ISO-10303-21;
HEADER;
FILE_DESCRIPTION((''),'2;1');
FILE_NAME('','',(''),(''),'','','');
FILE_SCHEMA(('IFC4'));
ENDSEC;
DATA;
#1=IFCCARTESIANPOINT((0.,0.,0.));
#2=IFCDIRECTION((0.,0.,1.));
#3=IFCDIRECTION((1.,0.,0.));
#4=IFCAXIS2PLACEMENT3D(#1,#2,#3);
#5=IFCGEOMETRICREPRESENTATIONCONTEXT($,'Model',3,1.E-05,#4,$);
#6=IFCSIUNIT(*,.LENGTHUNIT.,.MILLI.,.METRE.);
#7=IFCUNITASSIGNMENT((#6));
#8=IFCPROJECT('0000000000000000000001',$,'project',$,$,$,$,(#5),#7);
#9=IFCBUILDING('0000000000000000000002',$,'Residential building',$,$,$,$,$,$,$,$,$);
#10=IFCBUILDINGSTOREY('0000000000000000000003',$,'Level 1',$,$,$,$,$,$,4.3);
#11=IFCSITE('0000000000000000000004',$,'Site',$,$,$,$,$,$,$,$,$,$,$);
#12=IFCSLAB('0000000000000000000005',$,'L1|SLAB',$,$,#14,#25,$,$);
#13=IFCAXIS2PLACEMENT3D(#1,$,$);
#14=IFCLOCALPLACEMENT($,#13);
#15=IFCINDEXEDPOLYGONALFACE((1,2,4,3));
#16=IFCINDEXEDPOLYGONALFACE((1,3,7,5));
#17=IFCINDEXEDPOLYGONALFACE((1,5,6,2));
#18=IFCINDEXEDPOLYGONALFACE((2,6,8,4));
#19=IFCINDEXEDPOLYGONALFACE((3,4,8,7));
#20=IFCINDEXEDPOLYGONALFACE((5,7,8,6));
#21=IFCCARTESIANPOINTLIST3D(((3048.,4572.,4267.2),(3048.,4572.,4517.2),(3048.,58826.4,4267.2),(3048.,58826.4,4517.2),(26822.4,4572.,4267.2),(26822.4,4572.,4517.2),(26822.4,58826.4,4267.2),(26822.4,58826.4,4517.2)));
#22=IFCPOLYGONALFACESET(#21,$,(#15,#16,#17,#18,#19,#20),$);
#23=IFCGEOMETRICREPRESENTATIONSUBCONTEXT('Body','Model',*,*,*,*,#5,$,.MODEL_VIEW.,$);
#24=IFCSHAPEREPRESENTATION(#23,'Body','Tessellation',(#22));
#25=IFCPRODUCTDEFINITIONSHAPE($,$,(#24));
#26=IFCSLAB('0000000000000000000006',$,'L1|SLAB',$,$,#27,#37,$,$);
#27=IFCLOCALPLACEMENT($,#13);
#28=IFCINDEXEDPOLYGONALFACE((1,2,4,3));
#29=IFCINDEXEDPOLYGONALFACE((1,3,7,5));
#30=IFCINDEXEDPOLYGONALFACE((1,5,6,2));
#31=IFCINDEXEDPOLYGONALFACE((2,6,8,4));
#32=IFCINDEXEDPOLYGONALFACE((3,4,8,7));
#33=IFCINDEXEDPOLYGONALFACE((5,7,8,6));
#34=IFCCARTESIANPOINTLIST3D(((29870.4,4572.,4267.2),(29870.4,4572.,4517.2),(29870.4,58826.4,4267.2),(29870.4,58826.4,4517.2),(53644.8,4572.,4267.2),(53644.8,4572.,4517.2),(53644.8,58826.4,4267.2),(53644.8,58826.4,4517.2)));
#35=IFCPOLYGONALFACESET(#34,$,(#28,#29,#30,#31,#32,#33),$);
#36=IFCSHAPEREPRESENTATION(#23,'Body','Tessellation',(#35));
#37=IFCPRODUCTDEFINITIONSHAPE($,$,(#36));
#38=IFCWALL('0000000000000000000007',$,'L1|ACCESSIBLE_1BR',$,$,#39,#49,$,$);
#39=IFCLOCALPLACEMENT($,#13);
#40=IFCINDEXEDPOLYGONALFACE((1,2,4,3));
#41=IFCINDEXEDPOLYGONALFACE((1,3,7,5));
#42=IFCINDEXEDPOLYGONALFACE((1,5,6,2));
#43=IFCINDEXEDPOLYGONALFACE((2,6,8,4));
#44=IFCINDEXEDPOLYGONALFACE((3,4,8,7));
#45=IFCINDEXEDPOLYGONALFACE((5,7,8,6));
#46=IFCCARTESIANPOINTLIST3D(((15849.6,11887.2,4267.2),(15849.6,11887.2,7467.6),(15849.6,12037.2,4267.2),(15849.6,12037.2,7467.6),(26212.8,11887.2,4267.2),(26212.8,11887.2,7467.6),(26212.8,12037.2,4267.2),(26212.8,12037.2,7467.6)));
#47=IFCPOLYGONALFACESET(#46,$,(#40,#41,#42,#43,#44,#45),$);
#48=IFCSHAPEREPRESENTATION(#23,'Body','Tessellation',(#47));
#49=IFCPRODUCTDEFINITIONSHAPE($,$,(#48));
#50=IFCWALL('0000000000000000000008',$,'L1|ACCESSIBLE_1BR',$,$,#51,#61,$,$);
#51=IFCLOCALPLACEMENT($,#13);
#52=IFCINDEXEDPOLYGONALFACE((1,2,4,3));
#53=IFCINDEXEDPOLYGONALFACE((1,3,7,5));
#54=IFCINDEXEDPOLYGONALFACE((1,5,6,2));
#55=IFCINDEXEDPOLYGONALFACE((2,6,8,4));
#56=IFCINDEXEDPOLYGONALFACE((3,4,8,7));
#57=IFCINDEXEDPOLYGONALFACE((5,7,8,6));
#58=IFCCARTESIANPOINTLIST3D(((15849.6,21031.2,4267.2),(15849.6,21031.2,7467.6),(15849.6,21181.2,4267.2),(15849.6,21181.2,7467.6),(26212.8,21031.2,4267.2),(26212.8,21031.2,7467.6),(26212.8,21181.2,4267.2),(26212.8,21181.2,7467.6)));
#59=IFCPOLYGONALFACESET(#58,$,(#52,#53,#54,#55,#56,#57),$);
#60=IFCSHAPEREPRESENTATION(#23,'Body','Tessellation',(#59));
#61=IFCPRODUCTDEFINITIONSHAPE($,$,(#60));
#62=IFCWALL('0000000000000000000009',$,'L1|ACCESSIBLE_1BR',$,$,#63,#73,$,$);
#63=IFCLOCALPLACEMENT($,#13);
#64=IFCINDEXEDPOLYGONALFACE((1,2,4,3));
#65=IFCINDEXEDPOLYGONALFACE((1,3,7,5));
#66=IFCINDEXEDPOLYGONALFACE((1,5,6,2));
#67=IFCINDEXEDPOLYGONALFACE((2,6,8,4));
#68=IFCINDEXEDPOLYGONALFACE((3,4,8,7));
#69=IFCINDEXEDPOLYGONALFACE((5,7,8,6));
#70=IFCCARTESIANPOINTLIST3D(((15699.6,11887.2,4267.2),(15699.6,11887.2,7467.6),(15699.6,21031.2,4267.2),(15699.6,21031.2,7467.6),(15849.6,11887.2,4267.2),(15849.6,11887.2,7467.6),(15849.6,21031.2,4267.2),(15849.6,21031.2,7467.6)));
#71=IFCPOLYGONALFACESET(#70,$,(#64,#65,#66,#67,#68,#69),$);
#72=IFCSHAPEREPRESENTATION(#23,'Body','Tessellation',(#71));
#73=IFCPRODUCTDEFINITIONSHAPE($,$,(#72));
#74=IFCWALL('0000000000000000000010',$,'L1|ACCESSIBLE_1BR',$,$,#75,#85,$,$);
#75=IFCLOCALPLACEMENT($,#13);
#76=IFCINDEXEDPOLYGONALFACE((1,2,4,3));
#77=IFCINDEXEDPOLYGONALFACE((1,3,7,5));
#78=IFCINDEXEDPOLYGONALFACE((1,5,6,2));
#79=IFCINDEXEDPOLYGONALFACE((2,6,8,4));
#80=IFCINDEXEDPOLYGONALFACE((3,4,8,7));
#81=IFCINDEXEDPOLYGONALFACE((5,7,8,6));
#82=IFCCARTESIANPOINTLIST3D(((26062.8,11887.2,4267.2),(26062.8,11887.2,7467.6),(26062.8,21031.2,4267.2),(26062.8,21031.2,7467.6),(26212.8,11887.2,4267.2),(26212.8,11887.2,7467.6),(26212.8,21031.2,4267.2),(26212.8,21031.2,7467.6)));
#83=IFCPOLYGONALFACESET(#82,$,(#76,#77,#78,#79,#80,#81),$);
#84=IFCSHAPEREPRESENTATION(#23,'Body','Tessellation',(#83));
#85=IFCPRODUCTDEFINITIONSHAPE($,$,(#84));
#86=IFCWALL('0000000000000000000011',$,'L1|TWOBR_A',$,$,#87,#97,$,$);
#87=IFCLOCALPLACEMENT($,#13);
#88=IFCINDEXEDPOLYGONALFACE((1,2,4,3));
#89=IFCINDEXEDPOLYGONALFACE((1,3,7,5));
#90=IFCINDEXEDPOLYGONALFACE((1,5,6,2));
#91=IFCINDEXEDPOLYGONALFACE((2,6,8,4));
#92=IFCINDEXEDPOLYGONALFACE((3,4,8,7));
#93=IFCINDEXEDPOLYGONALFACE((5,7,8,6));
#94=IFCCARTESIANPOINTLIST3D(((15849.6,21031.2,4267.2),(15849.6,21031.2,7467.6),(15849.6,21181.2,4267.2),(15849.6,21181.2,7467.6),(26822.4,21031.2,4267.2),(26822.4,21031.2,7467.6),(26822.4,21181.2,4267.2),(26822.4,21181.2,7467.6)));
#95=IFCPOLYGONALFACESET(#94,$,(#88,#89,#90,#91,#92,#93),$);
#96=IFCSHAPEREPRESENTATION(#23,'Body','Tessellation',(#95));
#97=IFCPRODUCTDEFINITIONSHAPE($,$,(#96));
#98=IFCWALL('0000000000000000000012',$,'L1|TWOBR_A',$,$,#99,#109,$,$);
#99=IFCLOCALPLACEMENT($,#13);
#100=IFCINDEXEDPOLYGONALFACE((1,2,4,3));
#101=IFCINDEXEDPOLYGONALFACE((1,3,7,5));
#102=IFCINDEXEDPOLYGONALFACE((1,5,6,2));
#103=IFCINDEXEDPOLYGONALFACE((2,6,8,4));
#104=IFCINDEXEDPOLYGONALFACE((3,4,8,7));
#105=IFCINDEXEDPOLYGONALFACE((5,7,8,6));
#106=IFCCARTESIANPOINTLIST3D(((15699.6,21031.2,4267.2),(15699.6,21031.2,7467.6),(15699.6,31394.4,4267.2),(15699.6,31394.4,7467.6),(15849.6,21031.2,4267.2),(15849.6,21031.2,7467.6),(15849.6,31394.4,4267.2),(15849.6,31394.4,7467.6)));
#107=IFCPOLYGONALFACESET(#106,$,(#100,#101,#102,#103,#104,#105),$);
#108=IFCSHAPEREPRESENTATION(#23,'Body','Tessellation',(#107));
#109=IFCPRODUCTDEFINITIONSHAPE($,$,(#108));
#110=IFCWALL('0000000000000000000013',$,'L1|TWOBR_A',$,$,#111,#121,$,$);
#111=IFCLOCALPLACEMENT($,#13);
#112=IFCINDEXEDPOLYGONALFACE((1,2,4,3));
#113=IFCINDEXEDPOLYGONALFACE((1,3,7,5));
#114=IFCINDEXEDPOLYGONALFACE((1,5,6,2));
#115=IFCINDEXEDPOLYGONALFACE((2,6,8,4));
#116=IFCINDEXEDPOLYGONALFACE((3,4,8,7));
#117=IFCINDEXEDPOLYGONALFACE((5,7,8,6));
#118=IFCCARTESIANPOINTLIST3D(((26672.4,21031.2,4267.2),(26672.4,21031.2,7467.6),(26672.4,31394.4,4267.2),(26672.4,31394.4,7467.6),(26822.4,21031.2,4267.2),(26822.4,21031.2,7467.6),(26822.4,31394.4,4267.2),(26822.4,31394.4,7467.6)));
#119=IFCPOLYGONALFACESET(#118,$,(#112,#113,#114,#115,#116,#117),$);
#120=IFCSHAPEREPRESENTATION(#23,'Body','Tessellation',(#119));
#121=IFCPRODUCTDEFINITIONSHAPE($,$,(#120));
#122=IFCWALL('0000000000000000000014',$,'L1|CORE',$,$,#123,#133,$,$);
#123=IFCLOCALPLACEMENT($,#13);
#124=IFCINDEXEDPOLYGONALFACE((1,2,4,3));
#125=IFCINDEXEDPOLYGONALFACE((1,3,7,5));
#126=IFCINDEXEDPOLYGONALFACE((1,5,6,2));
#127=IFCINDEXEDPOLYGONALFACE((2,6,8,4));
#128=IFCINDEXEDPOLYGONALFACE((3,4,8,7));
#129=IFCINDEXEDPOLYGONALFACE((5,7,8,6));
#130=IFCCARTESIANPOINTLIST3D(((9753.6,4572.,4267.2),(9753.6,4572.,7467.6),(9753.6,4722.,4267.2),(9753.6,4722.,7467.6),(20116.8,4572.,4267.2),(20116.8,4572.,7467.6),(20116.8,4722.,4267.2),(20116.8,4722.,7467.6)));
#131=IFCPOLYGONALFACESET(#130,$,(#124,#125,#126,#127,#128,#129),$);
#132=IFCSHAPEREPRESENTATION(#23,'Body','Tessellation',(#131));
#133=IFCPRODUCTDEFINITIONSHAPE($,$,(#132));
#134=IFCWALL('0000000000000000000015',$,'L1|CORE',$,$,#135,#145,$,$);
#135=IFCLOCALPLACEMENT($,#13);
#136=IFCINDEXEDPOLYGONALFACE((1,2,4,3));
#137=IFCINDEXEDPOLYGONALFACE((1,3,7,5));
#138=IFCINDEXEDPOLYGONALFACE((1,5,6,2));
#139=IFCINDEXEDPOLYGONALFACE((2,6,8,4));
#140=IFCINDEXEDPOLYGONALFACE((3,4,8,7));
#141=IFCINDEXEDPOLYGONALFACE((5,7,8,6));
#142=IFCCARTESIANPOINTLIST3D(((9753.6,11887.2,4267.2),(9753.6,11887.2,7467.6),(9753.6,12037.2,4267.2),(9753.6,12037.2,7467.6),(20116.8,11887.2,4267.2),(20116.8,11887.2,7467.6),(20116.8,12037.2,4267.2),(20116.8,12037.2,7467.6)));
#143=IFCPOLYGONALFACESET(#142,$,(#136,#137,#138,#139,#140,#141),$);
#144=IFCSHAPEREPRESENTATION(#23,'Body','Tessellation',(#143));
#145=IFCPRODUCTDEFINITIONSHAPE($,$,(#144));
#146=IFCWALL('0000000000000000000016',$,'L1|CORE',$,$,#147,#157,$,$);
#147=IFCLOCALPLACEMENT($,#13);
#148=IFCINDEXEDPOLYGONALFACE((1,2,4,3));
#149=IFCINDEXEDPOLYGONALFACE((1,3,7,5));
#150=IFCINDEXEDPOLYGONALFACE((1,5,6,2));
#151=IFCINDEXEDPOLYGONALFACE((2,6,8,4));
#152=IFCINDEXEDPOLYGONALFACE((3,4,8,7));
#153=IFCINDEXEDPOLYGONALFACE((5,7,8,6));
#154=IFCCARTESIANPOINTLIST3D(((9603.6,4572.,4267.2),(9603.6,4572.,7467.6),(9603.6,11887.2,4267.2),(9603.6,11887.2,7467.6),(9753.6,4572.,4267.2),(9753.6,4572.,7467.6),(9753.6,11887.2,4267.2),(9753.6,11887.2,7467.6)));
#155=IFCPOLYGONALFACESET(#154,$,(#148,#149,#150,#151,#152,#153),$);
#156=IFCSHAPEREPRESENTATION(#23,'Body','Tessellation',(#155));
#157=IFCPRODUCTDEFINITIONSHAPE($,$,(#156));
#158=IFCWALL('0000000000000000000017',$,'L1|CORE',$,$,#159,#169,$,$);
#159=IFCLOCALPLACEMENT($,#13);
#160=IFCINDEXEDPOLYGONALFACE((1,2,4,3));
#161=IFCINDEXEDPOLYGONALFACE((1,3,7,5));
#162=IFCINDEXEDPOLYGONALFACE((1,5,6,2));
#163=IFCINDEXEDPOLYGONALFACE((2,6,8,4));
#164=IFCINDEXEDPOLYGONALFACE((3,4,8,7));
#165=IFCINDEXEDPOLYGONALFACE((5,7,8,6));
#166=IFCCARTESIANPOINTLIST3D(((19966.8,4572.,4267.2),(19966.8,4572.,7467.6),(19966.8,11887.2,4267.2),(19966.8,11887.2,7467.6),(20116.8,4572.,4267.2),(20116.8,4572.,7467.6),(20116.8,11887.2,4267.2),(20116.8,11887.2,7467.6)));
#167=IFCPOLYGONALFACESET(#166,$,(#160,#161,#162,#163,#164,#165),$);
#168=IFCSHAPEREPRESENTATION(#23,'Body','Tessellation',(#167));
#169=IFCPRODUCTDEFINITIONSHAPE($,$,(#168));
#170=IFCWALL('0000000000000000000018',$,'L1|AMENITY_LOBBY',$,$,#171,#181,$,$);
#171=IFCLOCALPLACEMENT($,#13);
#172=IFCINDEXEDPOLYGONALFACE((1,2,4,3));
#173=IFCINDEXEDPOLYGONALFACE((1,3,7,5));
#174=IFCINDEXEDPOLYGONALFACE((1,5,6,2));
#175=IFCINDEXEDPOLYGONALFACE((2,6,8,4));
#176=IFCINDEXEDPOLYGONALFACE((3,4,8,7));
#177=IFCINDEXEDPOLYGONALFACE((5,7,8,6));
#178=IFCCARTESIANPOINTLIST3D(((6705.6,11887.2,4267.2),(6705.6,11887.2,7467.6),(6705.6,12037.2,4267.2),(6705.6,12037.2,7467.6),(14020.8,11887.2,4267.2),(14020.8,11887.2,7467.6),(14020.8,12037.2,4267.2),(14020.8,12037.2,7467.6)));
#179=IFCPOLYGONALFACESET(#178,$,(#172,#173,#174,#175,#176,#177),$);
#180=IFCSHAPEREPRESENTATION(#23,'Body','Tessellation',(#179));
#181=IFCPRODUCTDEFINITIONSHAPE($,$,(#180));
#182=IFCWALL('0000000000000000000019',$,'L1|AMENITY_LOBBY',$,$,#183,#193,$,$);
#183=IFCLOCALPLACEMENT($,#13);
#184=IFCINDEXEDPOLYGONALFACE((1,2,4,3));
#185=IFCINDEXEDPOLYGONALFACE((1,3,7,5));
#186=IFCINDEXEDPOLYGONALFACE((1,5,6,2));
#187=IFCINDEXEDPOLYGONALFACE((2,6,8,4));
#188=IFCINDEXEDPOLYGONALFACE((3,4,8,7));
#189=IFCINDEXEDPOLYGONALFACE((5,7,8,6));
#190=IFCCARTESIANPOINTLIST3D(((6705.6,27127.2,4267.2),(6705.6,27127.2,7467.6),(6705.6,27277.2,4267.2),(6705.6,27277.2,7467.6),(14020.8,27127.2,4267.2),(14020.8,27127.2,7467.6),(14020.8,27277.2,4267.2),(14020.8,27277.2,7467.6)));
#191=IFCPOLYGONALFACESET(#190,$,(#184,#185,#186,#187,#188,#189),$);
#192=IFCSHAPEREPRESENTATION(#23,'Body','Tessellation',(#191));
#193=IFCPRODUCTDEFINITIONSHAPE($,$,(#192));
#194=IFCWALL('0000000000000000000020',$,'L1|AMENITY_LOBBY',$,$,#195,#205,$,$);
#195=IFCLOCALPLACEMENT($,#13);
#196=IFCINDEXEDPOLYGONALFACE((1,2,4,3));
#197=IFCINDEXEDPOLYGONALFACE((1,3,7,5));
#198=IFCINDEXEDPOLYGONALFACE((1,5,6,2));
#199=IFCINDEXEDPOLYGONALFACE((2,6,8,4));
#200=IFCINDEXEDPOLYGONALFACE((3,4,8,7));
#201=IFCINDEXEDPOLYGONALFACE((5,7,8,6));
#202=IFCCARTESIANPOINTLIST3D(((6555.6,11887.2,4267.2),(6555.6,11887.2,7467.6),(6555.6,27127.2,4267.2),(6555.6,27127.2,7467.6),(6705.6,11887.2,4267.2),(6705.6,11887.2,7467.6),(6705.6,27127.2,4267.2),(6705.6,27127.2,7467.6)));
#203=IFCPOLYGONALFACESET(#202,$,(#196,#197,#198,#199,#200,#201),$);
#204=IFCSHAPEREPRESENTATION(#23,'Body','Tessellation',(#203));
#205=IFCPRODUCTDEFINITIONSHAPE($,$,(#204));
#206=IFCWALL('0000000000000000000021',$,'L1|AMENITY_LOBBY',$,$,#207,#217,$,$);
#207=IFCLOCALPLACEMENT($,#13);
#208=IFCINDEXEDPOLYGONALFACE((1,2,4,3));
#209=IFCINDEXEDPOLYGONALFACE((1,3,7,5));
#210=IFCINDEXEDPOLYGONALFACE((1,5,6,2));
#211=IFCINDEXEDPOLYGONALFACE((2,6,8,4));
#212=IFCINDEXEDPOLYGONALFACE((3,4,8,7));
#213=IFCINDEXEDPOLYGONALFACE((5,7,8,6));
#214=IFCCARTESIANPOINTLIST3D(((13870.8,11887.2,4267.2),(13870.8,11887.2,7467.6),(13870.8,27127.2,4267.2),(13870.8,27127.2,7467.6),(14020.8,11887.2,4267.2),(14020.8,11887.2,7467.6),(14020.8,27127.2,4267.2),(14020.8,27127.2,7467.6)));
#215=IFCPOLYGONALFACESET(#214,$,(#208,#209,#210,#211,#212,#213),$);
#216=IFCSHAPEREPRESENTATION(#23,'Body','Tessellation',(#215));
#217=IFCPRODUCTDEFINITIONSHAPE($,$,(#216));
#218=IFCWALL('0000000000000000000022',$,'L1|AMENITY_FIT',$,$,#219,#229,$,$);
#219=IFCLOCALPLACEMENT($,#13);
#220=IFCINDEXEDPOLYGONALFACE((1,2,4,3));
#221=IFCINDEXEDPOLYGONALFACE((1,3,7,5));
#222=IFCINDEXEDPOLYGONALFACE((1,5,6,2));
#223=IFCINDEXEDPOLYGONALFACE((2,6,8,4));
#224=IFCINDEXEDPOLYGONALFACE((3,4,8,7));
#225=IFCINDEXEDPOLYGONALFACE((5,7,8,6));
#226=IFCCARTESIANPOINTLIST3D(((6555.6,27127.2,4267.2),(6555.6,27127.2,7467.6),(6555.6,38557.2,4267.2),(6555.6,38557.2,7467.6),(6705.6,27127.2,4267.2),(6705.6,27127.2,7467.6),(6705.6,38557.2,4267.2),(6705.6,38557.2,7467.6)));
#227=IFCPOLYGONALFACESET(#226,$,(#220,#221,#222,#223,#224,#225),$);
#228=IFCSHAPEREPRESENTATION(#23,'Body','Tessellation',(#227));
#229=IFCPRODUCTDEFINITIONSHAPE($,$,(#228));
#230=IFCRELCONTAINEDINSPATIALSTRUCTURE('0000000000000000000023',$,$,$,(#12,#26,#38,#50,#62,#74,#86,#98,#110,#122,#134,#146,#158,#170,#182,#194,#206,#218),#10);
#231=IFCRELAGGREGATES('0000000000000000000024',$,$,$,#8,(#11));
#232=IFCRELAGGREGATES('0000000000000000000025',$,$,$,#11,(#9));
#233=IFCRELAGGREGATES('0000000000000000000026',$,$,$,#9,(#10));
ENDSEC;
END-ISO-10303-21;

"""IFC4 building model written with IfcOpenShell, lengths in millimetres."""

from ifc_helpers import new_model, si_unit, frame, origin_with_axes, place, context, subcontext, project, spatial, indexed_curve, outline, extrude, element, save


model = new_model("IFC4")

# Units and contexts
model_context = context("Model", 3, precision=1e-05, world=origin_with_axes())
body_context = subcontext(model_context, "Body", "Model", "MODEL_VIEW")
ifc_project = project(units=[si_unit("LENGTHUNIT", "METRE", prefix="MILLI")], contexts=[model_context])

# Site, building, storey
site = spatial("IfcSite", under=ifc_project, Name="Site")
building = spatial("IfcBuilding", under=site, Name="Residential building")
storey = spatial("IfcBuildingStorey", under=building, Name="Level 1", Elevation=4.3)

# Slabs
for number, where, z_axis, x_axis, name in (
    (1, (3048.0, 4572.0, 4267.2), (0.0, 0.0, 1.0), (1.0, 0.0, 0.0), "L1|SLAB"),
    (2, (29870.4, 4572.0, 4267.2), (0.0, 0.0, 1.0), (1.0, 0.0, 0.0), "L1|SLAB"),
):
    element("IfcSlab", number, at=place(None, frame(where, z_axis=z_axis, x_axis=x_axis)), inside=storey, Name=name, context=body_context, shape_type="SweptSolid", body=[
        extrude(outline(indexed_curve([(0.0, 0.0), (23774.4, 0.0), (23774.4, 54254.4), (0.0, 54254.4), (0.0, 0.0)])), None, (0.0, 0.0, 1.0), 250.0),
    ])

# Walls
for number, where, z_axis, x_axis, name in (
    (3, (15849.6, 11887.2, 4267.2), (0.0, 0.0, 1.0), (1.0, 0.0, 0.0), "L1|ACCESSIBLE_1BR"),
    (4, (15849.6, 21031.2, 4267.2), (0.0, 0.0, 1.0), (1.0, 0.0, 0.0), "L1|ACCESSIBLE_1BR"),
):
    element("IfcWall", number, at=place(None, frame(where, z_axis=z_axis, x_axis=x_axis)), inside=storey, Name=name, context=body_context, shape_type="SweptSolid", body=[
        extrude(outline(indexed_curve([(0.0, 0.0), (0.0, 150.0), (10363.2, 150.0), (10363.2, 0.0), (0.0, 0.0)], self_intersect=False)), origin_with_axes(), (0.0, 0.0, 1.0), 3200.4),
    ])
for number, where, z_axis, x_axis, name in (
    (5, (15849.6, 11887.2, 4267.2), (0.0, 0.0, 1.0), (0.0, 1.0, 0.0), "L1|ACCESSIBLE_1BR"),
    (6, (26212.8, 11887.2, 4267.2), (0.0, 0.0, 1.0), (0.0, 1.0, 0.0), "L1|ACCESSIBLE_1BR"),
):
    element("IfcWall", number, at=place(None, frame(where, z_axis=z_axis, x_axis=x_axis)), inside=storey, Name=name, context=body_context, shape_type="SweptSolid", body=[
        extrude(outline(indexed_curve([(0.0, 0.0), (0.0, 150.0), (9144.0, 150.0), (9144.0, 0.0), (0.0, 0.0)], self_intersect=False)), origin_with_axes(), (0.0, 0.0, 1.0), 3200.4),
    ])
wall_1_placement = place(None, frame((15849.6, 21031.2, 4267.2), z_axis=(0.0, 0.0, 1.0), x_axis=(1.0, 0.0, 0.0)))
element("IfcWall", 7, at=wall_1_placement, inside=storey, Name="L1|TWOBR_A", context=body_context, shape_type="SweptSolid", body=[
    extrude(outline(indexed_curve([(0.0, 0.0), (0.0, 150.0), (10972.8, 150.0), (10972.8, 0.0), (0.0, 0.0)], self_intersect=False)), origin_with_axes(), (0.0, 0.0, 1.0), 3200.4),
])
for number, where, z_axis, x_axis, name in (
    (8, (15849.6, 21031.2, 4267.2), (0.0, 0.0, 1.0), (0.0, 1.0, 0.0), "L1|TWOBR_A"),
    (9, (26822.4, 21031.2, 4267.2), (0.0, 0.0, 1.0), (0.0, 1.0, 0.0), "L1|TWOBR_A"),
    (10, (9753.6, 4572.0, 4267.2), (0.0, 0.0, 1.0), (1.0, 0.0, 0.0), "L1|CORE"),
    (11, (9753.6, 11887.2, 4267.2), (0.0, 0.0, 1.0), (1.0, 0.0, 0.0), "L1|CORE"),
):
    element("IfcWall", number, at=place(None, frame(where, z_axis=z_axis, x_axis=x_axis)), inside=storey, Name=name, context=body_context, shape_type="SweptSolid", body=[
        extrude(outline(indexed_curve([(0.0, 0.0), (0.0, 150.0), (10363.2, 150.0), (10363.2, 0.0), (0.0, 0.0)], self_intersect=False)), origin_with_axes(), (0.0, 0.0, 1.0), 3200.4),
    ])
for number, where, z_axis, x_axis, name in (
    (12, (9753.6, 4572.0, 4267.2), (0.0, 0.0, 1.0), (0.0, 1.0, 0.0), "L1|CORE"),
    (13, (20116.8, 4572.0, 4267.2), (0.0, 0.0, 1.0), (0.0, 1.0, 0.0), "L1|CORE"),
    (14, (6705.6, 11887.2, 4267.2), (0.0, 0.0, 1.0), (1.0, 0.0, 0.0), "L1|AMENITY_LOBBY"),
    (15, (6705.6, 27127.2, 4267.2), (0.0, 0.0, 1.0), (1.0, 0.0, 0.0), "L1|AMENITY_LOBBY"),
):
    element("IfcWall", number, at=place(None, frame(where, z_axis=z_axis, x_axis=x_axis)), inside=storey, Name=name, context=body_context, shape_type="SweptSolid", body=[
        extrude(outline(indexed_curve([(0.0, 0.0), (0.0, 150.0), (7315.2, 150.0), (7315.2, 0.0), (0.0, 0.0)], self_intersect=False)), origin_with_axes(), (0.0, 0.0, 1.0), 3200.4),
    ])
for number, where, z_axis, x_axis, name in (
    (16, (6705.6, 11887.2, 4267.2), (0.0, 0.0, 1.0), (0.0, 1.0, 0.0), "L1|AMENITY_LOBBY"),
    (17, (14020.8, 11887.2, 4267.2), (0.0, 0.0, 1.0), (0.0, 1.0, 0.0), "L1|AMENITY_LOBBY"),
):
    element("IfcWall", number, at=place(None, frame(where, z_axis=z_axis, x_axis=x_axis)), inside=storey, Name=name, context=body_context, shape_type="SweptSolid", body=[
        extrude(outline(indexed_curve([(0.0, 0.0), (0.0, 150.0), (15240.0, 150.0), (15240.0, 0.0), (0.0, 0.0)], self_intersect=False)), origin_with_axes(), (0.0, 0.0, 1.0), 3200.4),
    ])
for number, where, z_axis, x_axis, name in (
    (18, (6705.6, 27127.2, 4267.2), (0.0, 0.0, 1.0), (0.0, 1.0, 0.0), "L1|AMENITY_FIT"),
):
    element("IfcWall", number, at=place(None, frame(where, z_axis=z_axis, x_axis=x_axis)), inside=storey, Name=name, context=body_context, shape_type="SweptSolid", body=[
        extrude(outline(indexed_curve([(0.0, 0.0), (0.0, 150.0), (11430.0, 150.0), (11430.0, 0.0), (0.0, 0.0)], self_intersect=False)), origin_with_axes(), (0.0, 0.0, 1.0), 3200.4),
    ])

save(model, "model.ifc")
